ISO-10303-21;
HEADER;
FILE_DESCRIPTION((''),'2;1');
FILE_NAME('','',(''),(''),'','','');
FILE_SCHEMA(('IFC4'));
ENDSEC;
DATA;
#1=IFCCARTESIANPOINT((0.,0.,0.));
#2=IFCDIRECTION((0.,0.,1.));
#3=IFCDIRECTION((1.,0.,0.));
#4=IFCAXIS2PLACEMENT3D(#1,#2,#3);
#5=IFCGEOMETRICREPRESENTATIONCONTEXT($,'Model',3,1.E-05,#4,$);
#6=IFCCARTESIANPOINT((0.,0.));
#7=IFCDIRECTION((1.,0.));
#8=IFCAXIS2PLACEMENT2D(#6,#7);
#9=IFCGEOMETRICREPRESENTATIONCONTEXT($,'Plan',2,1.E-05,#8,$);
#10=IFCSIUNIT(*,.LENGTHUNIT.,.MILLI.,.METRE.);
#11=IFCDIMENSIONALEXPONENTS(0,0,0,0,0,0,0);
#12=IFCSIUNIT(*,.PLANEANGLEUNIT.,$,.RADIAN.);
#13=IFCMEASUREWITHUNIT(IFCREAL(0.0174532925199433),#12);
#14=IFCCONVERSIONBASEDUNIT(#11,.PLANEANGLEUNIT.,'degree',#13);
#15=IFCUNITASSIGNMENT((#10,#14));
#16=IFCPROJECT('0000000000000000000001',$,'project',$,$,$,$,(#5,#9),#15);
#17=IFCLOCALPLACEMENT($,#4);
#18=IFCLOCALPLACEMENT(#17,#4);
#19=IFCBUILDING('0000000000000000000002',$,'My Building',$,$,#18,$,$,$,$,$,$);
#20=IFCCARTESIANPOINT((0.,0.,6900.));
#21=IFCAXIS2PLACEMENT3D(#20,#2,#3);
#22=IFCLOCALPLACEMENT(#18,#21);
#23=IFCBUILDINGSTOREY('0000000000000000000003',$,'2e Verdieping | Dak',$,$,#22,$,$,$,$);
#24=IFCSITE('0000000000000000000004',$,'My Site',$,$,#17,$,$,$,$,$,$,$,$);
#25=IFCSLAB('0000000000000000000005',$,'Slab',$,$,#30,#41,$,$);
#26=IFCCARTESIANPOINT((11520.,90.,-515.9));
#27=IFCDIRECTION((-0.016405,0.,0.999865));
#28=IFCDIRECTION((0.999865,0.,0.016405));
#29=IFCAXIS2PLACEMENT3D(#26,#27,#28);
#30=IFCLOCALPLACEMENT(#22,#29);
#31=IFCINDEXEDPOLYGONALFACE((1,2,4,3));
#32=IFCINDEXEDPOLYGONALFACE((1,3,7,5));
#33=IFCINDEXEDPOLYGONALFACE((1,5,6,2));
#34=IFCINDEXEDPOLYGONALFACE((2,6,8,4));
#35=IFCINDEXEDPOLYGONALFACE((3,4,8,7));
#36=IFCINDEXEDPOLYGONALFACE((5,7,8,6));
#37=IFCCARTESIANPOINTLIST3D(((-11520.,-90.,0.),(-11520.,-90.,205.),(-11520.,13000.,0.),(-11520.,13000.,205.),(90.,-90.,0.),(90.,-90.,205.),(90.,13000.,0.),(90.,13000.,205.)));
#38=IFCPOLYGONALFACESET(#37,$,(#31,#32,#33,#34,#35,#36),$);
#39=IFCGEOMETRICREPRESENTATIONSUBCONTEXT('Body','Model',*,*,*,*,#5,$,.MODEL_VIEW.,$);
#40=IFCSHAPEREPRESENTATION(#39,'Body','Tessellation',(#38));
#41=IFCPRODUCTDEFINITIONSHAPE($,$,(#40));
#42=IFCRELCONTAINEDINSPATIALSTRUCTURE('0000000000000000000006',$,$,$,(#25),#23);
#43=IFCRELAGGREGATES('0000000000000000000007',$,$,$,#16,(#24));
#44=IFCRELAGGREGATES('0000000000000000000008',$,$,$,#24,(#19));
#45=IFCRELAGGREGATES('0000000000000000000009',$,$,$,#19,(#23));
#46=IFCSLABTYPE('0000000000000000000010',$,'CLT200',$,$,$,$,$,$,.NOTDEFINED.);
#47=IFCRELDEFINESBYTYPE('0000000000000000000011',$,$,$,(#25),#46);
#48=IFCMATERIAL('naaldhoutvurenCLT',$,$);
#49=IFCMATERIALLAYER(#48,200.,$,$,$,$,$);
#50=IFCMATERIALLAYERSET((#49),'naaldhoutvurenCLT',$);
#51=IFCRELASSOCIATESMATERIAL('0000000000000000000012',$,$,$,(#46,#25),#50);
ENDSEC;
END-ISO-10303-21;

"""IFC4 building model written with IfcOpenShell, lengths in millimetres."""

from ifc_helpers import new_model, entity, si_unit, converted_unit, frame, origin_with_axes, origin_2d_with_axis, place, context, subcontext, project, spatial, line, indexed_curve, outline, extrude, material, layer, layer_set, layer_usage, type_object, element, save


model = new_model("IFC4")

# Units and contexts
model_context = context("Model", 3, precision=1e-05, world=origin_with_axes())
plan_context = context("Plan", 2, precision=1e-05, world=origin_2d_with_axis())
body_context = subcontext(model_context, "Body", "Model", "MODEL_VIEW")
ifc_project = project(units=[si_unit("LENGTHUNIT", "METRE", prefix="MILLI"), converted_unit("PLANEANGLEUNIT", "degree", entity("IfcReal", 0.0174532925199433), si_unit("PLANEANGLEUNIT", "RADIAN"), dimensions=[0, 0, 0, 0, 0, 0, 0])], contexts=[model_context, plan_context])

# Site, building, storey
site_placement = place(None, origin_with_axes())
site = spatial("IfcSite", under=ifc_project, at=site_placement, Name="My Site")
building_placement = place(site_placement, origin_with_axes())
building = spatial("IfcBuilding", under=site, at=building_placement, Name="My Building")
storey_placement = place(building_placement, frame((0.0, 0.0, 6900.0), z_axis=(0.0, 0.0, 1.0), x_axis=(1.0, 0.0, 0.0)))
storey = spatial("IfcBuildingStorey", under=building, at=storey_placement, Name="2e Verdieping | Dak")

# Slab
ifc_material_1 = material(Name="naaldhoutvurenCLT")
ifc_layer_1 = layer(ifc_material_1, 200.0)
ifc_layer_set_1 = layer_set([ifc_layer_1], Name="naaldhoutvurenCLT")
ifc_layer_usage_1 = layer_usage(ifc_layer_set_1, "AXIS3", "POSITIVE", 0.0)
slab_type_1 = type_object("IfcSlabType", Name="CLT200", PredefinedType="NOTDEFINED", material=ifc_layer_set_1)
slab_1_placement = place(storey_placement, frame((11520.0, 90.0, -515.9), z_axis=(-0.016405, 0.0, 0.999865), x_axis=(0.999865, 0.0, 0.016405)))
element("IfcSlab", 1, at=slab_1_placement, inside=storey, type_object=slab_type_1, material=ifc_layer_usage_1, Name="Slab", context=body_context, shape_type="SweptSolid", body=[
    extrude(outline(indexed_curve([(-11520.0, -90.0), (-11520.0, 13000.0), (90.0, 13000.0), (90.0, -90.0)], segments=[line(4, 1), line(1, 2), line(2, 3), line(3, 4)], self_intersect=False)), None, (0.0, 0.0, 1.0), 205.0),
])

save(model, "model.ifc")
